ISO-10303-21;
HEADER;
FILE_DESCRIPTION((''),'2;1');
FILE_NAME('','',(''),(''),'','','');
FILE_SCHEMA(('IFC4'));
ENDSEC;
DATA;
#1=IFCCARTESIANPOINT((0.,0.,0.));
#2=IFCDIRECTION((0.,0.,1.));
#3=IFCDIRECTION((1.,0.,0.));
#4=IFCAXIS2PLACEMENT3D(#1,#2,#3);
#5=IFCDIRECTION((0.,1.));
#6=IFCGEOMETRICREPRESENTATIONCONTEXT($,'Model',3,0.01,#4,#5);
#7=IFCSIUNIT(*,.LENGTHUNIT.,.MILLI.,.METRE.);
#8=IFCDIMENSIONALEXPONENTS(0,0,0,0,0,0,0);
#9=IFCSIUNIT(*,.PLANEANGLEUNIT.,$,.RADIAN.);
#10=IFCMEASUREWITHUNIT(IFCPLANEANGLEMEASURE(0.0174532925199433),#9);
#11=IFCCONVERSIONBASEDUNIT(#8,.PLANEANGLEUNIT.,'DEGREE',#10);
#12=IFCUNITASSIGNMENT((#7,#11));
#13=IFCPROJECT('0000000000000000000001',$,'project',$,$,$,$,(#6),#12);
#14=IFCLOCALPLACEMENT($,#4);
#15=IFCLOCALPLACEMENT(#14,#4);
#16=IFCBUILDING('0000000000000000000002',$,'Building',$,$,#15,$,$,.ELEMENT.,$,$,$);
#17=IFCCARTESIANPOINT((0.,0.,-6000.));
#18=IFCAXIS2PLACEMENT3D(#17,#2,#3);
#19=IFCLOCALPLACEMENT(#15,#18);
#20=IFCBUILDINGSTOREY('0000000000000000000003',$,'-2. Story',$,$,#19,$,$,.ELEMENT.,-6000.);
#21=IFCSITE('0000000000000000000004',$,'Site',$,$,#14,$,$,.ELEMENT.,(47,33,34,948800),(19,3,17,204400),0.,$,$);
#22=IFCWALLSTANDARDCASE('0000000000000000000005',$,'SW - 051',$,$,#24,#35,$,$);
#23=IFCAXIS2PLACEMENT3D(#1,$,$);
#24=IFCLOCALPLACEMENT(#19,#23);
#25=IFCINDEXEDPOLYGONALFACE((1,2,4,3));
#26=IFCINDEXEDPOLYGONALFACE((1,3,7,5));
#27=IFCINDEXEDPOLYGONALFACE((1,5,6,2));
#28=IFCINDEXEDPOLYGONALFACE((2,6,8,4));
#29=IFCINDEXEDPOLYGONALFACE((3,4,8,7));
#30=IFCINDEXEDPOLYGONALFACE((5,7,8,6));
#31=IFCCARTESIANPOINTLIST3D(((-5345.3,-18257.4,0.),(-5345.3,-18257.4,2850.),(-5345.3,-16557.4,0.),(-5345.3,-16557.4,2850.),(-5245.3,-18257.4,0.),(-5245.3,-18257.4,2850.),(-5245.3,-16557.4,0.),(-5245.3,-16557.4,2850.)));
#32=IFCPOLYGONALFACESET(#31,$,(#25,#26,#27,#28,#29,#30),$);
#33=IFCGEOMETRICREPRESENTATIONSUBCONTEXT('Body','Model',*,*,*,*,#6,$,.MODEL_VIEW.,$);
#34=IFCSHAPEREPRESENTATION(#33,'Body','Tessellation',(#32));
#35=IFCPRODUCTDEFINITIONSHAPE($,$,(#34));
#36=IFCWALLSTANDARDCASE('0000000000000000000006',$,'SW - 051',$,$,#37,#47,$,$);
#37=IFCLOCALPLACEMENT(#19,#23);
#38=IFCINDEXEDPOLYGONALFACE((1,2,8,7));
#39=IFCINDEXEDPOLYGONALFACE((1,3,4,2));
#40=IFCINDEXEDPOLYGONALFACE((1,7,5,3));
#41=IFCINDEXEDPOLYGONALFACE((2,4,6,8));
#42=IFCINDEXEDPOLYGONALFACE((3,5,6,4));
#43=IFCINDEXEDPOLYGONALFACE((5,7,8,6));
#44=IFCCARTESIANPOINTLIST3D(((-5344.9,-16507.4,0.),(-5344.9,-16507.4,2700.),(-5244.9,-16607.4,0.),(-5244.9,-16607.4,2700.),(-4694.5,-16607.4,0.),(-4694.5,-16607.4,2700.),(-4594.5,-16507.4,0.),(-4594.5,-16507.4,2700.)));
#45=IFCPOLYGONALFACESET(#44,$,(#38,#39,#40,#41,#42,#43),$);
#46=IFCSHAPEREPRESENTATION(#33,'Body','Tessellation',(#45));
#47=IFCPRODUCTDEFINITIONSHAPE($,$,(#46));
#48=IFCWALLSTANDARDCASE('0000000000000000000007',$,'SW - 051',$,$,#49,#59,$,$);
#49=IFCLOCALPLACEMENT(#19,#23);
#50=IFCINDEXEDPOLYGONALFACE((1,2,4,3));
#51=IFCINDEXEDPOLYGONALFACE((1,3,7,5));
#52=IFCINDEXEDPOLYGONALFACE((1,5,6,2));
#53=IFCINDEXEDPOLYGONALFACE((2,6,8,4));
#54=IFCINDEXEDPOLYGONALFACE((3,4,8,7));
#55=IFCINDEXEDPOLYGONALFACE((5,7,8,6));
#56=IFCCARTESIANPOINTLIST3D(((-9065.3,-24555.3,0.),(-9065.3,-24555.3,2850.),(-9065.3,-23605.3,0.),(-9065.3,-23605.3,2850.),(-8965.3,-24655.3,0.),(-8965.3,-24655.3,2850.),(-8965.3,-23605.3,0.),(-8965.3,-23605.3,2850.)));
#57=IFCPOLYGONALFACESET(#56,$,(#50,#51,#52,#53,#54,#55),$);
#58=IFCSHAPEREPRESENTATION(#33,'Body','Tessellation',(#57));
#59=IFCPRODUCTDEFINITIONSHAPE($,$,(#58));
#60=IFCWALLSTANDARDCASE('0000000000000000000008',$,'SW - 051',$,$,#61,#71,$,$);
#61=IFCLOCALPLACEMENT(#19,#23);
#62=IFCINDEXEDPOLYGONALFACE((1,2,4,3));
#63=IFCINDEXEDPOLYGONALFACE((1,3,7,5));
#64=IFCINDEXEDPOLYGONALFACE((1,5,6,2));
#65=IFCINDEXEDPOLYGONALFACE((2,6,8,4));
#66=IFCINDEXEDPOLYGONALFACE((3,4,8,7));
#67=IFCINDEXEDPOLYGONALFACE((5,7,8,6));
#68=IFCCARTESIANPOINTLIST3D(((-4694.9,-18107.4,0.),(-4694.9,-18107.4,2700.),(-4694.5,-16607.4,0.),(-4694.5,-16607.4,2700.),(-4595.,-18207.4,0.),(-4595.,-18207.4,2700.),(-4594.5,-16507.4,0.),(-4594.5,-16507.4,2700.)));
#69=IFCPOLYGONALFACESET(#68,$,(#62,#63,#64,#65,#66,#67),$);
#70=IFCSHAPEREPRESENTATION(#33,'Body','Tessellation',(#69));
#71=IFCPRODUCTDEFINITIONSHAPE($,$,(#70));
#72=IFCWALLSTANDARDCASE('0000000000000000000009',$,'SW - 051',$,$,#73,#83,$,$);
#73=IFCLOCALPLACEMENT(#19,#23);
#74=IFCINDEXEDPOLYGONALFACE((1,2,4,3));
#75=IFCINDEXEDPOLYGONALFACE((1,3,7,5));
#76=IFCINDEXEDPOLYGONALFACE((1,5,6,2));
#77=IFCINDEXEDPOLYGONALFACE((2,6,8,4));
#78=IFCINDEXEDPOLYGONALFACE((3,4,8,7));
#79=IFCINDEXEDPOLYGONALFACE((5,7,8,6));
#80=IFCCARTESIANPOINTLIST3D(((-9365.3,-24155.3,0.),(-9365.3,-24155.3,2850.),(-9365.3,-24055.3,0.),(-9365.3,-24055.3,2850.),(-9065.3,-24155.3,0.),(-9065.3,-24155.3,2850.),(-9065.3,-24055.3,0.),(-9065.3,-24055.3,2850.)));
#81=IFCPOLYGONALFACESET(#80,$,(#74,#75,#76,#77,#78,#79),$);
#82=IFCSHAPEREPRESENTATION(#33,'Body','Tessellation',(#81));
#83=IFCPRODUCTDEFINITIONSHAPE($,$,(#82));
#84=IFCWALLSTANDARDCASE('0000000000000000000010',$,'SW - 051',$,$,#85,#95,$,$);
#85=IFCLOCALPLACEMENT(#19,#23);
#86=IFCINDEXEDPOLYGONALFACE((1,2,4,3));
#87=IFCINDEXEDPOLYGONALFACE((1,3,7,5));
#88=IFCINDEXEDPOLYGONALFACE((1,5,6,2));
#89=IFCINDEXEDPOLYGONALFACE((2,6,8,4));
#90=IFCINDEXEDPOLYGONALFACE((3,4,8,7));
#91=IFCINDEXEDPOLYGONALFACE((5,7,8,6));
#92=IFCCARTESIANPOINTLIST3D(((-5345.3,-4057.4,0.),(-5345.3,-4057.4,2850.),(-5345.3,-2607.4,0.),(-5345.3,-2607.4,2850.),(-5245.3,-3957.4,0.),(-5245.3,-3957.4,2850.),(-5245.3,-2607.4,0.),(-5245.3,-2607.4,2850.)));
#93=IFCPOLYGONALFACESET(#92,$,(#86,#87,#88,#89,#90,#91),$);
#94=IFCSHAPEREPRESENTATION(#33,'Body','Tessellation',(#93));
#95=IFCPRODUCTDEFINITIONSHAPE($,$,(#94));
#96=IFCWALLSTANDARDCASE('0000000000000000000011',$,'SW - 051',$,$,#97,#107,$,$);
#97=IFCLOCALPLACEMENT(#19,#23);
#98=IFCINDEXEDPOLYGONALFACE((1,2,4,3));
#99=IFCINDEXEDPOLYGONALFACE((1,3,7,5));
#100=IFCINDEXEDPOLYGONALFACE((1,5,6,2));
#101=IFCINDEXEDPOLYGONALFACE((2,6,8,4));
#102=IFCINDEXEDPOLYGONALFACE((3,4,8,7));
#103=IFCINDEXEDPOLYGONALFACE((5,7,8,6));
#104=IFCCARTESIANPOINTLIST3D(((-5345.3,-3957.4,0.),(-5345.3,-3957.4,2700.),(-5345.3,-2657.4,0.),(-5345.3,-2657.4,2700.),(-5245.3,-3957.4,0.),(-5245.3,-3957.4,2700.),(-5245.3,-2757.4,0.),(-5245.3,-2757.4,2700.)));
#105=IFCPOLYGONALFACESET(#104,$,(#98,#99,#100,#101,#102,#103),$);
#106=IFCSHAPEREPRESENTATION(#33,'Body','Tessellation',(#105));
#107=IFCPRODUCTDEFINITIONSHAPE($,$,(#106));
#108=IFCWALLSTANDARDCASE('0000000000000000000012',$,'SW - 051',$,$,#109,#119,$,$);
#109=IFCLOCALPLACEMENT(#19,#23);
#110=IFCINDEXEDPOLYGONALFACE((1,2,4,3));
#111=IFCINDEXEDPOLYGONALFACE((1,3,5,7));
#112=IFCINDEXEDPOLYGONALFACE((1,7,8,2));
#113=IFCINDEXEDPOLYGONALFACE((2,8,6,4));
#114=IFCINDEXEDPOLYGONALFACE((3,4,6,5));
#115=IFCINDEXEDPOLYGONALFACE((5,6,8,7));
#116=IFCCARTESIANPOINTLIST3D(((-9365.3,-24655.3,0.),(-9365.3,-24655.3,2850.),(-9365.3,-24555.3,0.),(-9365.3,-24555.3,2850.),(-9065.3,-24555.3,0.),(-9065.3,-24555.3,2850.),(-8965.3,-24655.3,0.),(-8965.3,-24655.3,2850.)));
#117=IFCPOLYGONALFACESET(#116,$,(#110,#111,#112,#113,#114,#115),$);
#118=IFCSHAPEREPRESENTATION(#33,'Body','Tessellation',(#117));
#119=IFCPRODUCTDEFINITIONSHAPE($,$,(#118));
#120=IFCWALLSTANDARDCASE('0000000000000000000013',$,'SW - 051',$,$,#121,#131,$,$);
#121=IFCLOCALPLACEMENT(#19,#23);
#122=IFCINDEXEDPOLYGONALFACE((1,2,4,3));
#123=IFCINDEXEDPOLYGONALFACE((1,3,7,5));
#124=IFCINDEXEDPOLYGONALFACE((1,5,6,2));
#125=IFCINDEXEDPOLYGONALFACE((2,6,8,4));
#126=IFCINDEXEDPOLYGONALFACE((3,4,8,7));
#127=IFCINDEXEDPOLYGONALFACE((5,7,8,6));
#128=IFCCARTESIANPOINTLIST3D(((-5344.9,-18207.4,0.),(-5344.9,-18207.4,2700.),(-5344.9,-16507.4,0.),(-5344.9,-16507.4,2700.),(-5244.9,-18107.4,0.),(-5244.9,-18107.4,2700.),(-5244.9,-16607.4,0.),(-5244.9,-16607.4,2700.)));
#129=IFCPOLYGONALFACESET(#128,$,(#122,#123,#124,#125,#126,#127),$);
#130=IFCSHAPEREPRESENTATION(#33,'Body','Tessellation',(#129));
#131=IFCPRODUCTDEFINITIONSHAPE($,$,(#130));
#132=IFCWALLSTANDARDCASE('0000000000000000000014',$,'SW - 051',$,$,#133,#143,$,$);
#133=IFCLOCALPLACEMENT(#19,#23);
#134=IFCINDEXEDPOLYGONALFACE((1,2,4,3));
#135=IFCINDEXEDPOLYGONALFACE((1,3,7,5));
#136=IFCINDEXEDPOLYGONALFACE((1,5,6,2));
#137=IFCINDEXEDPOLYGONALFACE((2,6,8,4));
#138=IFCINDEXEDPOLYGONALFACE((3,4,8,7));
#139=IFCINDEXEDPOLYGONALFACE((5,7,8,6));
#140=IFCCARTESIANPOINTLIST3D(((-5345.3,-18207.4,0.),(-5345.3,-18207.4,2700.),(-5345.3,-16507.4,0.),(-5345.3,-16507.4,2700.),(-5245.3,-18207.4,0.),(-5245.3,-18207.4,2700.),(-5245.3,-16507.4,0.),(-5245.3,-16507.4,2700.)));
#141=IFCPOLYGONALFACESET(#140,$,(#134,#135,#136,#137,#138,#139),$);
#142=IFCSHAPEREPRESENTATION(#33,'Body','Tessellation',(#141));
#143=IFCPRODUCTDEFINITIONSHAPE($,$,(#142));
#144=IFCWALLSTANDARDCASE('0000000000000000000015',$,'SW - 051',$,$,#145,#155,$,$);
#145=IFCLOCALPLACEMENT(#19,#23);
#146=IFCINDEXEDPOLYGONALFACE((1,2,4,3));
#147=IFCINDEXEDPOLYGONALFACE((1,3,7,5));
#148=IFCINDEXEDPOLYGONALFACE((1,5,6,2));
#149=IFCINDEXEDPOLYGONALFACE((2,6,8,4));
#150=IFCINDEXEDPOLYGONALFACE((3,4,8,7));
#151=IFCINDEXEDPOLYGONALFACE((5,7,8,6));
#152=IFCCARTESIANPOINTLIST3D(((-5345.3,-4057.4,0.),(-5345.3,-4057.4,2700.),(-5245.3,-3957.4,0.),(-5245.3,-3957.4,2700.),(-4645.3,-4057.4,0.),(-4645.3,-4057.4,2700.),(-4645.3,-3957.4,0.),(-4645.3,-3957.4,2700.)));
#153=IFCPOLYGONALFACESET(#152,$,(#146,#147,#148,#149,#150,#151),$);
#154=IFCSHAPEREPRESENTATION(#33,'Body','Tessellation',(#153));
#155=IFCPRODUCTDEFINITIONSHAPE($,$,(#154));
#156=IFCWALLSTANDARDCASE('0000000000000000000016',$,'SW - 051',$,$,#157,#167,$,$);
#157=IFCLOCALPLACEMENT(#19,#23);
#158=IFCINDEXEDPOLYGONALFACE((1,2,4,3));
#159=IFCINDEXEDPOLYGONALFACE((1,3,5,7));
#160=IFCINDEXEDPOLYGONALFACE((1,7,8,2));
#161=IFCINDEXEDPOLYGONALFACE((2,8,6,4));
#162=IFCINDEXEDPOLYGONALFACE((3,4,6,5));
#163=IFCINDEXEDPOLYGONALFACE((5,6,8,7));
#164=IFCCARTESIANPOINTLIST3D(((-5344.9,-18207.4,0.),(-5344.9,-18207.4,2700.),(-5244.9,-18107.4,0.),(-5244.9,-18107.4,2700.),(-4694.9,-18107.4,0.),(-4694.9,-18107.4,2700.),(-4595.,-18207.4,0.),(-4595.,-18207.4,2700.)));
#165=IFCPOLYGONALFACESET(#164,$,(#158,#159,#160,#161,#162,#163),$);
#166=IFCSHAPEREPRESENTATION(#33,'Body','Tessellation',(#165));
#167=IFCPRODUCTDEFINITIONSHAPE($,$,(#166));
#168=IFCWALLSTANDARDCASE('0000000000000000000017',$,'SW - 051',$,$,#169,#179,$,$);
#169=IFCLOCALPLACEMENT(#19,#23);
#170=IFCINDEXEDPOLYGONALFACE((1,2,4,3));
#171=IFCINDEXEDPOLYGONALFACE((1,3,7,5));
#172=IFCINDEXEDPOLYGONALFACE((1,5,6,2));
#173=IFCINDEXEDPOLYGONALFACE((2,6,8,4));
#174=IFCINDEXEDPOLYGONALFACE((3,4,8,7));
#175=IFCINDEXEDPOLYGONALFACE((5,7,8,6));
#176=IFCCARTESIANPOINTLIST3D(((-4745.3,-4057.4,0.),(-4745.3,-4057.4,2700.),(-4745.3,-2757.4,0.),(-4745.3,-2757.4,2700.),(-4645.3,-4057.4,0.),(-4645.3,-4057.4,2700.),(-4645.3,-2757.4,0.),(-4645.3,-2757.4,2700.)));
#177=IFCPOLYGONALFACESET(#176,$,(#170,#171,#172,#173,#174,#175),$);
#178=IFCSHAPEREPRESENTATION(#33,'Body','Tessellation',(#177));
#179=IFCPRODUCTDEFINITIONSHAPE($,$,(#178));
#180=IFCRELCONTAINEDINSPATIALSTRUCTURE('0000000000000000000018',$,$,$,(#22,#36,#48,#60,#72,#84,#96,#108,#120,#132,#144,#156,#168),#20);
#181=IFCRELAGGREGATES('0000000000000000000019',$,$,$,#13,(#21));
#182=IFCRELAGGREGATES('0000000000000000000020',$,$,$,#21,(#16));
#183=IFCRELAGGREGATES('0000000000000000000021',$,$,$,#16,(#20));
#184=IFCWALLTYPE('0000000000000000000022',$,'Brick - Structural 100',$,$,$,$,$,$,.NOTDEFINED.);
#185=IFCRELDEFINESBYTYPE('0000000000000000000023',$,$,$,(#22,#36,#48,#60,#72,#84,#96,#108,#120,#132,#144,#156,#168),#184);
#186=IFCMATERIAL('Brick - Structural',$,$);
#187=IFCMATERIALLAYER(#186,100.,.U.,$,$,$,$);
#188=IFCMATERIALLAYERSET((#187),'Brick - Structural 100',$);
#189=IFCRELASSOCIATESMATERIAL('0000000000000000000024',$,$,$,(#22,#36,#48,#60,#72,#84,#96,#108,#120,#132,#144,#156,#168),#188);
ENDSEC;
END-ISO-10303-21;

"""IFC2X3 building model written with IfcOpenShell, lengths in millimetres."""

from ifc_helpers import new_model, entity, si_unit, converted_unit, direction, frame, origin_with_axes, place, context, subcontext, project, spatial, polyline, outline, extrude, material, layer, layer_set, layer_usage, type_object, element, save


model = new_model("IFC2X3")

# Units and contexts
model_context = context("Model", 3, precision=0.01, world=origin_with_axes(), true_north=direction((0.0, 1.0)))
body_context = subcontext(model_context, "Body", "Model", "MODEL_VIEW")
ifc_project = project(units=[si_unit("LENGTHUNIT", "METRE", prefix="MILLI"), converted_unit("PLANEANGLEUNIT", "DEGREE", entity("IfcPlaneAngleMeasure", 0.0174532925199433), si_unit("PLANEANGLEUNIT", "RADIAN"), dimensions=[0, 0, 0, 0, 0, 0, 0])], contexts=[model_context])

# Site, building, storey
site_placement = place(None, origin_with_axes())
site = spatial("IfcSite", under=ifc_project, at=site_placement, Name="Site", CompositionType="ELEMENT", RefLatitude=(47, 33, 34, 948800), RefLongitude=(19, 3, 17, 204400), RefElevation=0.0)
building_placement = place(site_placement, origin_with_axes())
building = spatial("IfcBuilding", under=site, at=building_placement, Name="Building", CompositionType="ELEMENT")
storey_placement = place(building_placement, frame((0.0, 0.0, -6000.0), z_axis=(0.0, 0.0, 1.0), x_axis=(1.0, 0.0, 0.0)))
storey = spatial("IfcBuildingStorey", under=building, at=storey_placement, Name="-2. Story", CompositionType="ELEMENT", Elevation=-6000.0)

# Shared definitions
ifc_material_1 = material(Name="Brick - Structural")

# Walls
ifc_layer_1 = layer(ifc_material_1, 100.0, ventilated="UNKNOWN")
ifc_layer_set_1 = layer_set([ifc_layer_1], Name="Brick - Structural 100")
ifc_layer_usage_1 = layer_usage(ifc_layer_set_1, "AXIS2", "NEGATIVE", 0.0)
wall_type_1 = type_object("IfcWallType", Name="Brick - Structural 100", PredefinedType="NOTDEFINED")
wall_1_placement = place(storey_placement, frame((-5345.3, -18257.4, 0.0), z_axis=(0.0, 0.0, 1.0), x_axis=(0.0, 1.0, 0.0)))
element("IfcWallStandardCase", 1, at=wall_1_placement, inside=storey, type_object=wall_type_1, material=ifc_layer_usage_1, Name="SW - 051", context=body_context, shape_type="SweptSolid", body=[
    extrude(outline(polyline([(0.0, -100.0), (1700.0, -100.0), (1700.0, 0.0), (0.0, 0.0), (0.0, -100.0)])), origin_with_axes(), (0.0, 0.0, 1.0), 2850.0),
])
ifc_layer_usage_2 = layer_usage(ifc_layer_set_1, "AXIS2", "NEGATIVE", 0.0)
wall_2_placement = place(storey_placement, frame((-5344.9, -16507.4, 0.0), z_axis=(0.0, 0.0, 1.0), x_axis=(1.0, 0.0, 0.0)))
element("IfcWallStandardCase", 2, at=wall_2_placement, inside=storey, type_object=wall_type_1, material=ifc_layer_usage_2, Name="SW - 051", context=body_context, shape_type="SweptSolid", body=[
    extrude(outline(polyline([(100.0, -100.0), (650.4, -100.0), (750.4, 0.0), (0.0, 0.0), (100.0, -100.0)])), origin_with_axes(), (0.0, 0.0, 1.0), 2700.0),
])
ifc_layer_usage_3 = layer_usage(ifc_layer_set_1, "AXIS2", "NEGATIVE", 0.0)
wall_3_placement = place(storey_placement, frame((-9065.3, -24655.3, 0.0), z_axis=(0.0, 0.0, 1.0), x_axis=(0.0, 1.0, 0.0)))
element("IfcWallStandardCase", 3, at=wall_3_placement, inside=storey, type_object=wall_type_1, material=ifc_layer_usage_3, Name="SW - 051", context=body_context, shape_type="SweptSolid", body=[
    extrude(outline(polyline([(0.0, -100.0), (1050.0, -100.0), (1050.0, 0.0), (100.0, 0.0), (0.0, -100.0)])), origin_with_axes(), (0.0, 0.0, 1.0), 2850.0),
])
ifc_layer_usage_4 = layer_usage(ifc_layer_set_1, "AXIS2", "NEGATIVE", 0.0)
wall_4_placement = place(storey_placement, frame((-4694.9, -18107.4, 0.0), z_axis=(0.0, 0.0, 1.0), x_axis=(0.000256, 1.0, 0.0)))
element("IfcWallStandardCase", 4, at=wall_4_placement, inside=storey, type_object=wall_type_1, material=ifc_layer_usage_4, Name="SW - 051", context=body_context, shape_type="SweptSolid", body=[
    extrude(outline(polyline([(-100.0, -100.0), (1600.0, -100.0), (1500.0, 0.0), (0.0, 0.0), (-100.0, -100.0)])), origin_with_axes(), (0.0, 0.0, 1.0), 2700.0),
])
ifc_layer_usage_5 = layer_usage(ifc_layer_set_1, "AXIS2", "NEGATIVE", 0.0)
wall_5_placement = place(storey_placement, frame((-9065.3, -24155.3, 0.0), z_axis=(0.0, 0.0, 1.0), x_axis=(-1.0, 0.0, 0.0)))
element("IfcWallStandardCase", 5, at=wall_5_placement, inside=storey, type_object=wall_type_1, material=ifc_layer_usage_5, Name="SW - 051", context=body_context, shape_type="SweptSolid", body=[
    extrude(outline(polyline([(0.0, -100.0), (300.0, -100.0), (300.0, 0.0), (0.0, 0.0), (0.0, -100.0)])), origin_with_axes(), (0.0, 0.0, 1.0), 2850.0),
])
ifc_layer_usage_6 = layer_usage(ifc_layer_set_1, "AXIS2", "NEGATIVE", 0.0)
wall_6_placement = place(storey_placement, frame((-5345.3, -3957.4, 0.0), z_axis=(0.0, 0.0, 1.0), x_axis=(0.0, 1.0, 0.0)))
element("IfcWallStandardCase", 6, at=wall_6_placement, inside=storey, type_object=wall_type_1, material=ifc_layer_usage_6, Name="SW - 051", context=body_context, shape_type="SweptSolid", body=[
    extrude(outline(polyline([(0.0, -100.0), (1350.0, -100.0), (1350.0, 0.0), (-100.0, 0.0), (0.0, -100.0)])), origin_with_axes(), (0.0, 0.0, 1.0), 2850.0),
])
ifc_layer_usage_7 = layer_usage(ifc_layer_set_1, "AXIS2", "NEGATIVE", 0.0)
wall_7_placement = place(storey_placement, frame((-5345.3, -3957.4, 0.0), z_axis=(0.0, 0.0, 1.0), x_axis=(0.0, 1.0, 0.0)))
element("IfcWallStandardCase", 7, at=wall_7_placement, inside=storey, type_object=wall_type_1, material=ifc_layer_usage_7, Name="SW - 051", context=body_context, shape_type="SweptSolid", body=[
    extrude(outline(polyline([(0.0, -100.0), (1200.0, -100.0), (1300.0, 0.0), (0.0, 0.0), (0.0, -100.0)])), origin_with_axes(), (0.0, 0.0, 1.0), 2700.0),
])
ifc_layer_usage_8 = layer_usage(ifc_layer_set_1, "AXIS2", "NEGATIVE", 0.0)
wall_8_placement = place(storey_placement, frame((-9065.3, -24655.3, 0.0), z_axis=(0.0, 0.0, 1.0), x_axis=(-1.0, 0.0, 0.0)))
element("IfcWallStandardCase", 8, at=wall_8_placement, inside=storey, type_object=wall_type_1, material=ifc_layer_usage_8, Name="SW - 051", context=body_context, shape_type="SweptSolid", body=[
    extrude(outline(polyline([(0.0, -100.0), (300.0, -100.0), (300.0, 0.0), (-100.0, 0.0), (0.0, -100.0)])), origin_with_axes(), (0.0, 0.0, 1.0), 2850.0),
])
ifc_layer_usage_9 = layer_usage(ifc_layer_set_1, "AXIS2", "NEGATIVE", 0.0)
wall_9_placement = place(storey_placement, frame((-5344.9, -18107.4, 0.0), z_axis=(0.0, 0.0, 1.0), x_axis=(0.0, 1.0, 0.0)))
element("IfcWallStandardCase", 9, at=wall_9_placement, inside=storey, type_object=wall_type_1, material=ifc_layer_usage_9, Name="SW - 051", context=body_context, shape_type="SweptSolid", body=[
    extrude(outline(polyline([(0.0, -100.0), (1500.0, -100.0), (1600.0, 0.0), (-100.0, 0.0), (0.0, -100.0)])), origin_with_axes(), (0.0, 0.0, 1.0), 2700.0),
])
ifc_layer_usage_10 = layer_usage(ifc_layer_set_1, "AXIS2", "NEGATIVE", 0.0)
wall_10_placement = place(storey_placement, frame((-5345.3, -18207.4, 0.0), z_axis=(0.0, 0.0, 1.0), x_axis=(0.0, 1.0, 0.0)))
element("IfcWallStandardCase", 10, at=wall_10_placement, inside=storey, type_object=wall_type_1, material=ifc_layer_usage_10, Name="SW - 051", context=body_context, shape_type="SweptSolid", body=[
    extrude(outline(polyline([(0.0, -100.0), (1700.0, -100.0), (1700.0, 0.0), (0.0, 0.0), (0.0, -100.0)])), origin_with_axes(), (0.0, 0.0, 1.0), 2700.0),
])
ifc_layer_usage_11 = layer_usage(ifc_layer_set_1, "AXIS2", "NEGATIVE", 0.0)
wall_11_placement = place(storey_placement, frame((-5345.3, -3957.4, 0.0), z_axis=(0.0, 0.0, 1.0), x_axis=(1.0, 0.0, 0.0)))
element("IfcWallStandardCase", 11, at=wall_11_placement, inside=storey, type_object=wall_type_1, material=ifc_layer_usage_11, Name="SW - 051", context=body_context, shape_type="SweptSolid", body=[
    extrude(outline(polyline([(0.0, -100.0), (700.0, -100.0), (700.0, 0.0), (100.0, 0.0), (0.0, -100.0)])), origin_with_axes(), (0.0, 0.0, 1.0), 2700.0),
])
ifc_layer_usage_12 = layer_usage(ifc_layer_set_1, "AXIS2", "NEGATIVE", 0.0)
wall_12_placement = place(storey_placement, frame((-5344.9, -18107.4, 0.0), z_axis=(0.0, 0.0, 1.0), x_axis=(1.0, 0.0, 0.0)))
element("IfcWallStandardCase", 12, at=wall_12_placement, inside=storey, type_object=wall_type_1, material=ifc_layer_usage_12, Name="SW - 051", context=body_context, shape_type="SweptSolid", body=[
    extrude(outline(polyline([(0.0, -100.0), (750.0, -100.0), (650.0, 0.0), (100.0, 0.0), (0.0, -100.0)])), origin_with_axes(), (0.0, 0.0, 1.0), 2700.0),
])
ifc_layer_usage_13 = layer_usage(ifc_layer_set_1, "AXIS2", "NEGATIVE", 0.0)
wall_13_placement = place(storey_placement, frame((-4745.3, -4057.4, 0.0), z_axis=(0.0, 0.0, 1.0), x_axis=(0.0, 1.0, 0.0)))
element("IfcWallStandardCase", 13, at=wall_13_placement, inside=storey, type_object=wall_type_1, material=ifc_layer_usage_13, Name="SW - 051", context=body_context, shape_type="SweptSolid", body=[
    extrude(outline(polyline([(0.0, -100.0), (1300.0, -100.0), (1300.0, 0.0), (0.0, 0.0), (0.0, -100.0)])), origin_with_axes(), (0.0, 0.0, 1.0), 2700.0),
])

save(model, "model.ifc")
